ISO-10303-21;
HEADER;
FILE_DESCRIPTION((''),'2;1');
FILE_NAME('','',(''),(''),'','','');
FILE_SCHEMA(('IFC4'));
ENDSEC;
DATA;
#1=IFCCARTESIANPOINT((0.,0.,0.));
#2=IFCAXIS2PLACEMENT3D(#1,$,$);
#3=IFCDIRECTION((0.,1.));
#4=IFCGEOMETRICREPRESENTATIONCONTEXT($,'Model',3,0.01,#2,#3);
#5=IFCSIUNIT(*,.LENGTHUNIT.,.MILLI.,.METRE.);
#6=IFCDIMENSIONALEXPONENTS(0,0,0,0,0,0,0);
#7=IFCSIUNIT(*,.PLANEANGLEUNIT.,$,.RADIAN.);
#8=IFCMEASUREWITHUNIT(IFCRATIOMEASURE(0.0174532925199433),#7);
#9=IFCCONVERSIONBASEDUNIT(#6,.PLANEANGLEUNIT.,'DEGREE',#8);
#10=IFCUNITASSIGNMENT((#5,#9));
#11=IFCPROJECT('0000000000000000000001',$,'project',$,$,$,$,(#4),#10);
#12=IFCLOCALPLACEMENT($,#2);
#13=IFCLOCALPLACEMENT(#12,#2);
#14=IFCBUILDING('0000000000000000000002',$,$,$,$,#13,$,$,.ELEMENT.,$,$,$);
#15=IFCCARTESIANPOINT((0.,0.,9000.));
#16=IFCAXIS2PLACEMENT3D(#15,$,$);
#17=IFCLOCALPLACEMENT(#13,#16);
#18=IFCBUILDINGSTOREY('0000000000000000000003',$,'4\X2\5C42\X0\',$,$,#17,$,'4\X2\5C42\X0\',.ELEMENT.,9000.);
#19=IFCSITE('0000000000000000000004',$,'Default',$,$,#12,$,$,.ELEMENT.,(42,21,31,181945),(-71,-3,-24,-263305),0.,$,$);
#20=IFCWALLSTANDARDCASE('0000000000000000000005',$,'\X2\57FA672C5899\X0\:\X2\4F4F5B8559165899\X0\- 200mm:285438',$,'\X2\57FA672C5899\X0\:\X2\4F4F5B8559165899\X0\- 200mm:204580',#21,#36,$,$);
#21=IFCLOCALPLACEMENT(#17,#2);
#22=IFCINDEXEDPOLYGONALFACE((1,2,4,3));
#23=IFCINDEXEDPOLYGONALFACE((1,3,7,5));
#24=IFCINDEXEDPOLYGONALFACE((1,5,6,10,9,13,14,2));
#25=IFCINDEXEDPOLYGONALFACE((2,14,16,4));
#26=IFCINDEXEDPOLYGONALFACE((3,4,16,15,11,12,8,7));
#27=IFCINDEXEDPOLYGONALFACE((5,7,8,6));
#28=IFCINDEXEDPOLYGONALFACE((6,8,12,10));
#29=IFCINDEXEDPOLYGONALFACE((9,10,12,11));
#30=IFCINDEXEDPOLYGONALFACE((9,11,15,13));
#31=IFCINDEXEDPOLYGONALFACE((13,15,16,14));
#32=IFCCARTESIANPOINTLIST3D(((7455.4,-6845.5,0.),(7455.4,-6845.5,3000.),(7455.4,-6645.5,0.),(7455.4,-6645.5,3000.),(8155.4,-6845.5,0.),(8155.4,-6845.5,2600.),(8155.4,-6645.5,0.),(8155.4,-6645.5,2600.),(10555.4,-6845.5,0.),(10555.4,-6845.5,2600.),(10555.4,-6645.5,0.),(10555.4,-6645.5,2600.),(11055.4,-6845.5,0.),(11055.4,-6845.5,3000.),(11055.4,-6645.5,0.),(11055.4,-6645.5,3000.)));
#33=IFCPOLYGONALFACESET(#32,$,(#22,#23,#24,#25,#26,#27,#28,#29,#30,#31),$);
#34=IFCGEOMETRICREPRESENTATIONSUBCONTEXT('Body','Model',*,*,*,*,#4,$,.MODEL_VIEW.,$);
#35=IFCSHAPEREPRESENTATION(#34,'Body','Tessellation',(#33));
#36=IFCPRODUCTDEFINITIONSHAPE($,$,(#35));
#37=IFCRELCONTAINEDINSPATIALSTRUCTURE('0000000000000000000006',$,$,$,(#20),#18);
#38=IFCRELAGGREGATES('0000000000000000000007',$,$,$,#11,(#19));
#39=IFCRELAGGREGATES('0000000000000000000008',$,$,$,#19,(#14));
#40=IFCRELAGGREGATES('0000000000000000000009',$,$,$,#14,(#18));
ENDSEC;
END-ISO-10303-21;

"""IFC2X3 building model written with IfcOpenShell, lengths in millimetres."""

from ifc_helpers import new_model, entity, si_unit, converted_unit, direction, frame, frame_2d, origin, place, context, subcontext, project, spatial, rectangle, extrude, element, save


model = new_model("IFC2X3")

# Units and contexts
model_context = context("Model", 3, precision=0.01, world=origin(), true_north=direction((0.0, 1.0)))
body_context = subcontext(model_context, "Body", "Model", "MODEL_VIEW")
ifc_project = project(units=[si_unit("LENGTHUNIT", "METRE", prefix="MILLI"), converted_unit("PLANEANGLEUNIT", "DEGREE", entity("IfcRatioMeasure", 0.0174532925199433), si_unit("PLANEANGLEUNIT", "RADIAN"), dimensions=[0, 0, 0, 0, 0, 0, 0])], contexts=[model_context])

# Site, building, storey
site_placement = place(None, origin())
site = spatial("IfcSite", under=ifc_project, at=site_placement, Name="Default", CompositionType="ELEMENT", RefLatitude=(42, 21, 31, 181945), RefLongitude=(-71, -3, -24, -263305), RefElevation=0.0)
building_placement = place(site_placement, origin())
building = spatial("IfcBuilding", under=site, at=building_placement, CompositionType="ELEMENT")
storey_placement = place(building_placement, frame((0.0, 0.0, 9000.0)))
storey = spatial("IfcBuildingStorey", under=building, at=storey_placement, Name="4层", LongName="4层", CompositionType="ELEMENT", Elevation=9000.0)

# Wall, opening
wall_placement = place(storey_placement, frame((7455.4, -6745.5, 0.0)))
wall = element("IfcWallStandardCase", 1, at=wall_placement, inside=storey, Name="基本墙:住宅外墙- 200mm:285438", ObjectType="基本墙:住宅外墙- 200mm:204580", context=body_context, shape_type="SweptSolid", body=[
    extrude(rectangle(XDim=3600.0, YDim=200.0, at=frame_2d((1800.0, 0.0), x_axis=(1.0, 0.0))), origin(), (0.0, 0.0, 1.0), 3000.0),
])
opening_placement = place(wall_placement, frame((3100.0, 100.0, 0.0)))
element("IfcOpeningElement", 2, at=opening_placement, cuts=wall, ObjectType="Opening", context=body_context, shape_type="SweptSolid", body=[
    extrude(rectangle(XDim=2600.0, YDim=2400.0, at=frame_2d((1300.0, 1200.0), x_axis=(1.0, 0.0))), frame((0.0, 0.0, 0.0), z_axis=(0.0, -1.0, 0.0), x_axis=(0.0, 0.0, 1.0)), (0.0, 0.0, 1.0), 200.0),
])

save(model, "model.ifc")
